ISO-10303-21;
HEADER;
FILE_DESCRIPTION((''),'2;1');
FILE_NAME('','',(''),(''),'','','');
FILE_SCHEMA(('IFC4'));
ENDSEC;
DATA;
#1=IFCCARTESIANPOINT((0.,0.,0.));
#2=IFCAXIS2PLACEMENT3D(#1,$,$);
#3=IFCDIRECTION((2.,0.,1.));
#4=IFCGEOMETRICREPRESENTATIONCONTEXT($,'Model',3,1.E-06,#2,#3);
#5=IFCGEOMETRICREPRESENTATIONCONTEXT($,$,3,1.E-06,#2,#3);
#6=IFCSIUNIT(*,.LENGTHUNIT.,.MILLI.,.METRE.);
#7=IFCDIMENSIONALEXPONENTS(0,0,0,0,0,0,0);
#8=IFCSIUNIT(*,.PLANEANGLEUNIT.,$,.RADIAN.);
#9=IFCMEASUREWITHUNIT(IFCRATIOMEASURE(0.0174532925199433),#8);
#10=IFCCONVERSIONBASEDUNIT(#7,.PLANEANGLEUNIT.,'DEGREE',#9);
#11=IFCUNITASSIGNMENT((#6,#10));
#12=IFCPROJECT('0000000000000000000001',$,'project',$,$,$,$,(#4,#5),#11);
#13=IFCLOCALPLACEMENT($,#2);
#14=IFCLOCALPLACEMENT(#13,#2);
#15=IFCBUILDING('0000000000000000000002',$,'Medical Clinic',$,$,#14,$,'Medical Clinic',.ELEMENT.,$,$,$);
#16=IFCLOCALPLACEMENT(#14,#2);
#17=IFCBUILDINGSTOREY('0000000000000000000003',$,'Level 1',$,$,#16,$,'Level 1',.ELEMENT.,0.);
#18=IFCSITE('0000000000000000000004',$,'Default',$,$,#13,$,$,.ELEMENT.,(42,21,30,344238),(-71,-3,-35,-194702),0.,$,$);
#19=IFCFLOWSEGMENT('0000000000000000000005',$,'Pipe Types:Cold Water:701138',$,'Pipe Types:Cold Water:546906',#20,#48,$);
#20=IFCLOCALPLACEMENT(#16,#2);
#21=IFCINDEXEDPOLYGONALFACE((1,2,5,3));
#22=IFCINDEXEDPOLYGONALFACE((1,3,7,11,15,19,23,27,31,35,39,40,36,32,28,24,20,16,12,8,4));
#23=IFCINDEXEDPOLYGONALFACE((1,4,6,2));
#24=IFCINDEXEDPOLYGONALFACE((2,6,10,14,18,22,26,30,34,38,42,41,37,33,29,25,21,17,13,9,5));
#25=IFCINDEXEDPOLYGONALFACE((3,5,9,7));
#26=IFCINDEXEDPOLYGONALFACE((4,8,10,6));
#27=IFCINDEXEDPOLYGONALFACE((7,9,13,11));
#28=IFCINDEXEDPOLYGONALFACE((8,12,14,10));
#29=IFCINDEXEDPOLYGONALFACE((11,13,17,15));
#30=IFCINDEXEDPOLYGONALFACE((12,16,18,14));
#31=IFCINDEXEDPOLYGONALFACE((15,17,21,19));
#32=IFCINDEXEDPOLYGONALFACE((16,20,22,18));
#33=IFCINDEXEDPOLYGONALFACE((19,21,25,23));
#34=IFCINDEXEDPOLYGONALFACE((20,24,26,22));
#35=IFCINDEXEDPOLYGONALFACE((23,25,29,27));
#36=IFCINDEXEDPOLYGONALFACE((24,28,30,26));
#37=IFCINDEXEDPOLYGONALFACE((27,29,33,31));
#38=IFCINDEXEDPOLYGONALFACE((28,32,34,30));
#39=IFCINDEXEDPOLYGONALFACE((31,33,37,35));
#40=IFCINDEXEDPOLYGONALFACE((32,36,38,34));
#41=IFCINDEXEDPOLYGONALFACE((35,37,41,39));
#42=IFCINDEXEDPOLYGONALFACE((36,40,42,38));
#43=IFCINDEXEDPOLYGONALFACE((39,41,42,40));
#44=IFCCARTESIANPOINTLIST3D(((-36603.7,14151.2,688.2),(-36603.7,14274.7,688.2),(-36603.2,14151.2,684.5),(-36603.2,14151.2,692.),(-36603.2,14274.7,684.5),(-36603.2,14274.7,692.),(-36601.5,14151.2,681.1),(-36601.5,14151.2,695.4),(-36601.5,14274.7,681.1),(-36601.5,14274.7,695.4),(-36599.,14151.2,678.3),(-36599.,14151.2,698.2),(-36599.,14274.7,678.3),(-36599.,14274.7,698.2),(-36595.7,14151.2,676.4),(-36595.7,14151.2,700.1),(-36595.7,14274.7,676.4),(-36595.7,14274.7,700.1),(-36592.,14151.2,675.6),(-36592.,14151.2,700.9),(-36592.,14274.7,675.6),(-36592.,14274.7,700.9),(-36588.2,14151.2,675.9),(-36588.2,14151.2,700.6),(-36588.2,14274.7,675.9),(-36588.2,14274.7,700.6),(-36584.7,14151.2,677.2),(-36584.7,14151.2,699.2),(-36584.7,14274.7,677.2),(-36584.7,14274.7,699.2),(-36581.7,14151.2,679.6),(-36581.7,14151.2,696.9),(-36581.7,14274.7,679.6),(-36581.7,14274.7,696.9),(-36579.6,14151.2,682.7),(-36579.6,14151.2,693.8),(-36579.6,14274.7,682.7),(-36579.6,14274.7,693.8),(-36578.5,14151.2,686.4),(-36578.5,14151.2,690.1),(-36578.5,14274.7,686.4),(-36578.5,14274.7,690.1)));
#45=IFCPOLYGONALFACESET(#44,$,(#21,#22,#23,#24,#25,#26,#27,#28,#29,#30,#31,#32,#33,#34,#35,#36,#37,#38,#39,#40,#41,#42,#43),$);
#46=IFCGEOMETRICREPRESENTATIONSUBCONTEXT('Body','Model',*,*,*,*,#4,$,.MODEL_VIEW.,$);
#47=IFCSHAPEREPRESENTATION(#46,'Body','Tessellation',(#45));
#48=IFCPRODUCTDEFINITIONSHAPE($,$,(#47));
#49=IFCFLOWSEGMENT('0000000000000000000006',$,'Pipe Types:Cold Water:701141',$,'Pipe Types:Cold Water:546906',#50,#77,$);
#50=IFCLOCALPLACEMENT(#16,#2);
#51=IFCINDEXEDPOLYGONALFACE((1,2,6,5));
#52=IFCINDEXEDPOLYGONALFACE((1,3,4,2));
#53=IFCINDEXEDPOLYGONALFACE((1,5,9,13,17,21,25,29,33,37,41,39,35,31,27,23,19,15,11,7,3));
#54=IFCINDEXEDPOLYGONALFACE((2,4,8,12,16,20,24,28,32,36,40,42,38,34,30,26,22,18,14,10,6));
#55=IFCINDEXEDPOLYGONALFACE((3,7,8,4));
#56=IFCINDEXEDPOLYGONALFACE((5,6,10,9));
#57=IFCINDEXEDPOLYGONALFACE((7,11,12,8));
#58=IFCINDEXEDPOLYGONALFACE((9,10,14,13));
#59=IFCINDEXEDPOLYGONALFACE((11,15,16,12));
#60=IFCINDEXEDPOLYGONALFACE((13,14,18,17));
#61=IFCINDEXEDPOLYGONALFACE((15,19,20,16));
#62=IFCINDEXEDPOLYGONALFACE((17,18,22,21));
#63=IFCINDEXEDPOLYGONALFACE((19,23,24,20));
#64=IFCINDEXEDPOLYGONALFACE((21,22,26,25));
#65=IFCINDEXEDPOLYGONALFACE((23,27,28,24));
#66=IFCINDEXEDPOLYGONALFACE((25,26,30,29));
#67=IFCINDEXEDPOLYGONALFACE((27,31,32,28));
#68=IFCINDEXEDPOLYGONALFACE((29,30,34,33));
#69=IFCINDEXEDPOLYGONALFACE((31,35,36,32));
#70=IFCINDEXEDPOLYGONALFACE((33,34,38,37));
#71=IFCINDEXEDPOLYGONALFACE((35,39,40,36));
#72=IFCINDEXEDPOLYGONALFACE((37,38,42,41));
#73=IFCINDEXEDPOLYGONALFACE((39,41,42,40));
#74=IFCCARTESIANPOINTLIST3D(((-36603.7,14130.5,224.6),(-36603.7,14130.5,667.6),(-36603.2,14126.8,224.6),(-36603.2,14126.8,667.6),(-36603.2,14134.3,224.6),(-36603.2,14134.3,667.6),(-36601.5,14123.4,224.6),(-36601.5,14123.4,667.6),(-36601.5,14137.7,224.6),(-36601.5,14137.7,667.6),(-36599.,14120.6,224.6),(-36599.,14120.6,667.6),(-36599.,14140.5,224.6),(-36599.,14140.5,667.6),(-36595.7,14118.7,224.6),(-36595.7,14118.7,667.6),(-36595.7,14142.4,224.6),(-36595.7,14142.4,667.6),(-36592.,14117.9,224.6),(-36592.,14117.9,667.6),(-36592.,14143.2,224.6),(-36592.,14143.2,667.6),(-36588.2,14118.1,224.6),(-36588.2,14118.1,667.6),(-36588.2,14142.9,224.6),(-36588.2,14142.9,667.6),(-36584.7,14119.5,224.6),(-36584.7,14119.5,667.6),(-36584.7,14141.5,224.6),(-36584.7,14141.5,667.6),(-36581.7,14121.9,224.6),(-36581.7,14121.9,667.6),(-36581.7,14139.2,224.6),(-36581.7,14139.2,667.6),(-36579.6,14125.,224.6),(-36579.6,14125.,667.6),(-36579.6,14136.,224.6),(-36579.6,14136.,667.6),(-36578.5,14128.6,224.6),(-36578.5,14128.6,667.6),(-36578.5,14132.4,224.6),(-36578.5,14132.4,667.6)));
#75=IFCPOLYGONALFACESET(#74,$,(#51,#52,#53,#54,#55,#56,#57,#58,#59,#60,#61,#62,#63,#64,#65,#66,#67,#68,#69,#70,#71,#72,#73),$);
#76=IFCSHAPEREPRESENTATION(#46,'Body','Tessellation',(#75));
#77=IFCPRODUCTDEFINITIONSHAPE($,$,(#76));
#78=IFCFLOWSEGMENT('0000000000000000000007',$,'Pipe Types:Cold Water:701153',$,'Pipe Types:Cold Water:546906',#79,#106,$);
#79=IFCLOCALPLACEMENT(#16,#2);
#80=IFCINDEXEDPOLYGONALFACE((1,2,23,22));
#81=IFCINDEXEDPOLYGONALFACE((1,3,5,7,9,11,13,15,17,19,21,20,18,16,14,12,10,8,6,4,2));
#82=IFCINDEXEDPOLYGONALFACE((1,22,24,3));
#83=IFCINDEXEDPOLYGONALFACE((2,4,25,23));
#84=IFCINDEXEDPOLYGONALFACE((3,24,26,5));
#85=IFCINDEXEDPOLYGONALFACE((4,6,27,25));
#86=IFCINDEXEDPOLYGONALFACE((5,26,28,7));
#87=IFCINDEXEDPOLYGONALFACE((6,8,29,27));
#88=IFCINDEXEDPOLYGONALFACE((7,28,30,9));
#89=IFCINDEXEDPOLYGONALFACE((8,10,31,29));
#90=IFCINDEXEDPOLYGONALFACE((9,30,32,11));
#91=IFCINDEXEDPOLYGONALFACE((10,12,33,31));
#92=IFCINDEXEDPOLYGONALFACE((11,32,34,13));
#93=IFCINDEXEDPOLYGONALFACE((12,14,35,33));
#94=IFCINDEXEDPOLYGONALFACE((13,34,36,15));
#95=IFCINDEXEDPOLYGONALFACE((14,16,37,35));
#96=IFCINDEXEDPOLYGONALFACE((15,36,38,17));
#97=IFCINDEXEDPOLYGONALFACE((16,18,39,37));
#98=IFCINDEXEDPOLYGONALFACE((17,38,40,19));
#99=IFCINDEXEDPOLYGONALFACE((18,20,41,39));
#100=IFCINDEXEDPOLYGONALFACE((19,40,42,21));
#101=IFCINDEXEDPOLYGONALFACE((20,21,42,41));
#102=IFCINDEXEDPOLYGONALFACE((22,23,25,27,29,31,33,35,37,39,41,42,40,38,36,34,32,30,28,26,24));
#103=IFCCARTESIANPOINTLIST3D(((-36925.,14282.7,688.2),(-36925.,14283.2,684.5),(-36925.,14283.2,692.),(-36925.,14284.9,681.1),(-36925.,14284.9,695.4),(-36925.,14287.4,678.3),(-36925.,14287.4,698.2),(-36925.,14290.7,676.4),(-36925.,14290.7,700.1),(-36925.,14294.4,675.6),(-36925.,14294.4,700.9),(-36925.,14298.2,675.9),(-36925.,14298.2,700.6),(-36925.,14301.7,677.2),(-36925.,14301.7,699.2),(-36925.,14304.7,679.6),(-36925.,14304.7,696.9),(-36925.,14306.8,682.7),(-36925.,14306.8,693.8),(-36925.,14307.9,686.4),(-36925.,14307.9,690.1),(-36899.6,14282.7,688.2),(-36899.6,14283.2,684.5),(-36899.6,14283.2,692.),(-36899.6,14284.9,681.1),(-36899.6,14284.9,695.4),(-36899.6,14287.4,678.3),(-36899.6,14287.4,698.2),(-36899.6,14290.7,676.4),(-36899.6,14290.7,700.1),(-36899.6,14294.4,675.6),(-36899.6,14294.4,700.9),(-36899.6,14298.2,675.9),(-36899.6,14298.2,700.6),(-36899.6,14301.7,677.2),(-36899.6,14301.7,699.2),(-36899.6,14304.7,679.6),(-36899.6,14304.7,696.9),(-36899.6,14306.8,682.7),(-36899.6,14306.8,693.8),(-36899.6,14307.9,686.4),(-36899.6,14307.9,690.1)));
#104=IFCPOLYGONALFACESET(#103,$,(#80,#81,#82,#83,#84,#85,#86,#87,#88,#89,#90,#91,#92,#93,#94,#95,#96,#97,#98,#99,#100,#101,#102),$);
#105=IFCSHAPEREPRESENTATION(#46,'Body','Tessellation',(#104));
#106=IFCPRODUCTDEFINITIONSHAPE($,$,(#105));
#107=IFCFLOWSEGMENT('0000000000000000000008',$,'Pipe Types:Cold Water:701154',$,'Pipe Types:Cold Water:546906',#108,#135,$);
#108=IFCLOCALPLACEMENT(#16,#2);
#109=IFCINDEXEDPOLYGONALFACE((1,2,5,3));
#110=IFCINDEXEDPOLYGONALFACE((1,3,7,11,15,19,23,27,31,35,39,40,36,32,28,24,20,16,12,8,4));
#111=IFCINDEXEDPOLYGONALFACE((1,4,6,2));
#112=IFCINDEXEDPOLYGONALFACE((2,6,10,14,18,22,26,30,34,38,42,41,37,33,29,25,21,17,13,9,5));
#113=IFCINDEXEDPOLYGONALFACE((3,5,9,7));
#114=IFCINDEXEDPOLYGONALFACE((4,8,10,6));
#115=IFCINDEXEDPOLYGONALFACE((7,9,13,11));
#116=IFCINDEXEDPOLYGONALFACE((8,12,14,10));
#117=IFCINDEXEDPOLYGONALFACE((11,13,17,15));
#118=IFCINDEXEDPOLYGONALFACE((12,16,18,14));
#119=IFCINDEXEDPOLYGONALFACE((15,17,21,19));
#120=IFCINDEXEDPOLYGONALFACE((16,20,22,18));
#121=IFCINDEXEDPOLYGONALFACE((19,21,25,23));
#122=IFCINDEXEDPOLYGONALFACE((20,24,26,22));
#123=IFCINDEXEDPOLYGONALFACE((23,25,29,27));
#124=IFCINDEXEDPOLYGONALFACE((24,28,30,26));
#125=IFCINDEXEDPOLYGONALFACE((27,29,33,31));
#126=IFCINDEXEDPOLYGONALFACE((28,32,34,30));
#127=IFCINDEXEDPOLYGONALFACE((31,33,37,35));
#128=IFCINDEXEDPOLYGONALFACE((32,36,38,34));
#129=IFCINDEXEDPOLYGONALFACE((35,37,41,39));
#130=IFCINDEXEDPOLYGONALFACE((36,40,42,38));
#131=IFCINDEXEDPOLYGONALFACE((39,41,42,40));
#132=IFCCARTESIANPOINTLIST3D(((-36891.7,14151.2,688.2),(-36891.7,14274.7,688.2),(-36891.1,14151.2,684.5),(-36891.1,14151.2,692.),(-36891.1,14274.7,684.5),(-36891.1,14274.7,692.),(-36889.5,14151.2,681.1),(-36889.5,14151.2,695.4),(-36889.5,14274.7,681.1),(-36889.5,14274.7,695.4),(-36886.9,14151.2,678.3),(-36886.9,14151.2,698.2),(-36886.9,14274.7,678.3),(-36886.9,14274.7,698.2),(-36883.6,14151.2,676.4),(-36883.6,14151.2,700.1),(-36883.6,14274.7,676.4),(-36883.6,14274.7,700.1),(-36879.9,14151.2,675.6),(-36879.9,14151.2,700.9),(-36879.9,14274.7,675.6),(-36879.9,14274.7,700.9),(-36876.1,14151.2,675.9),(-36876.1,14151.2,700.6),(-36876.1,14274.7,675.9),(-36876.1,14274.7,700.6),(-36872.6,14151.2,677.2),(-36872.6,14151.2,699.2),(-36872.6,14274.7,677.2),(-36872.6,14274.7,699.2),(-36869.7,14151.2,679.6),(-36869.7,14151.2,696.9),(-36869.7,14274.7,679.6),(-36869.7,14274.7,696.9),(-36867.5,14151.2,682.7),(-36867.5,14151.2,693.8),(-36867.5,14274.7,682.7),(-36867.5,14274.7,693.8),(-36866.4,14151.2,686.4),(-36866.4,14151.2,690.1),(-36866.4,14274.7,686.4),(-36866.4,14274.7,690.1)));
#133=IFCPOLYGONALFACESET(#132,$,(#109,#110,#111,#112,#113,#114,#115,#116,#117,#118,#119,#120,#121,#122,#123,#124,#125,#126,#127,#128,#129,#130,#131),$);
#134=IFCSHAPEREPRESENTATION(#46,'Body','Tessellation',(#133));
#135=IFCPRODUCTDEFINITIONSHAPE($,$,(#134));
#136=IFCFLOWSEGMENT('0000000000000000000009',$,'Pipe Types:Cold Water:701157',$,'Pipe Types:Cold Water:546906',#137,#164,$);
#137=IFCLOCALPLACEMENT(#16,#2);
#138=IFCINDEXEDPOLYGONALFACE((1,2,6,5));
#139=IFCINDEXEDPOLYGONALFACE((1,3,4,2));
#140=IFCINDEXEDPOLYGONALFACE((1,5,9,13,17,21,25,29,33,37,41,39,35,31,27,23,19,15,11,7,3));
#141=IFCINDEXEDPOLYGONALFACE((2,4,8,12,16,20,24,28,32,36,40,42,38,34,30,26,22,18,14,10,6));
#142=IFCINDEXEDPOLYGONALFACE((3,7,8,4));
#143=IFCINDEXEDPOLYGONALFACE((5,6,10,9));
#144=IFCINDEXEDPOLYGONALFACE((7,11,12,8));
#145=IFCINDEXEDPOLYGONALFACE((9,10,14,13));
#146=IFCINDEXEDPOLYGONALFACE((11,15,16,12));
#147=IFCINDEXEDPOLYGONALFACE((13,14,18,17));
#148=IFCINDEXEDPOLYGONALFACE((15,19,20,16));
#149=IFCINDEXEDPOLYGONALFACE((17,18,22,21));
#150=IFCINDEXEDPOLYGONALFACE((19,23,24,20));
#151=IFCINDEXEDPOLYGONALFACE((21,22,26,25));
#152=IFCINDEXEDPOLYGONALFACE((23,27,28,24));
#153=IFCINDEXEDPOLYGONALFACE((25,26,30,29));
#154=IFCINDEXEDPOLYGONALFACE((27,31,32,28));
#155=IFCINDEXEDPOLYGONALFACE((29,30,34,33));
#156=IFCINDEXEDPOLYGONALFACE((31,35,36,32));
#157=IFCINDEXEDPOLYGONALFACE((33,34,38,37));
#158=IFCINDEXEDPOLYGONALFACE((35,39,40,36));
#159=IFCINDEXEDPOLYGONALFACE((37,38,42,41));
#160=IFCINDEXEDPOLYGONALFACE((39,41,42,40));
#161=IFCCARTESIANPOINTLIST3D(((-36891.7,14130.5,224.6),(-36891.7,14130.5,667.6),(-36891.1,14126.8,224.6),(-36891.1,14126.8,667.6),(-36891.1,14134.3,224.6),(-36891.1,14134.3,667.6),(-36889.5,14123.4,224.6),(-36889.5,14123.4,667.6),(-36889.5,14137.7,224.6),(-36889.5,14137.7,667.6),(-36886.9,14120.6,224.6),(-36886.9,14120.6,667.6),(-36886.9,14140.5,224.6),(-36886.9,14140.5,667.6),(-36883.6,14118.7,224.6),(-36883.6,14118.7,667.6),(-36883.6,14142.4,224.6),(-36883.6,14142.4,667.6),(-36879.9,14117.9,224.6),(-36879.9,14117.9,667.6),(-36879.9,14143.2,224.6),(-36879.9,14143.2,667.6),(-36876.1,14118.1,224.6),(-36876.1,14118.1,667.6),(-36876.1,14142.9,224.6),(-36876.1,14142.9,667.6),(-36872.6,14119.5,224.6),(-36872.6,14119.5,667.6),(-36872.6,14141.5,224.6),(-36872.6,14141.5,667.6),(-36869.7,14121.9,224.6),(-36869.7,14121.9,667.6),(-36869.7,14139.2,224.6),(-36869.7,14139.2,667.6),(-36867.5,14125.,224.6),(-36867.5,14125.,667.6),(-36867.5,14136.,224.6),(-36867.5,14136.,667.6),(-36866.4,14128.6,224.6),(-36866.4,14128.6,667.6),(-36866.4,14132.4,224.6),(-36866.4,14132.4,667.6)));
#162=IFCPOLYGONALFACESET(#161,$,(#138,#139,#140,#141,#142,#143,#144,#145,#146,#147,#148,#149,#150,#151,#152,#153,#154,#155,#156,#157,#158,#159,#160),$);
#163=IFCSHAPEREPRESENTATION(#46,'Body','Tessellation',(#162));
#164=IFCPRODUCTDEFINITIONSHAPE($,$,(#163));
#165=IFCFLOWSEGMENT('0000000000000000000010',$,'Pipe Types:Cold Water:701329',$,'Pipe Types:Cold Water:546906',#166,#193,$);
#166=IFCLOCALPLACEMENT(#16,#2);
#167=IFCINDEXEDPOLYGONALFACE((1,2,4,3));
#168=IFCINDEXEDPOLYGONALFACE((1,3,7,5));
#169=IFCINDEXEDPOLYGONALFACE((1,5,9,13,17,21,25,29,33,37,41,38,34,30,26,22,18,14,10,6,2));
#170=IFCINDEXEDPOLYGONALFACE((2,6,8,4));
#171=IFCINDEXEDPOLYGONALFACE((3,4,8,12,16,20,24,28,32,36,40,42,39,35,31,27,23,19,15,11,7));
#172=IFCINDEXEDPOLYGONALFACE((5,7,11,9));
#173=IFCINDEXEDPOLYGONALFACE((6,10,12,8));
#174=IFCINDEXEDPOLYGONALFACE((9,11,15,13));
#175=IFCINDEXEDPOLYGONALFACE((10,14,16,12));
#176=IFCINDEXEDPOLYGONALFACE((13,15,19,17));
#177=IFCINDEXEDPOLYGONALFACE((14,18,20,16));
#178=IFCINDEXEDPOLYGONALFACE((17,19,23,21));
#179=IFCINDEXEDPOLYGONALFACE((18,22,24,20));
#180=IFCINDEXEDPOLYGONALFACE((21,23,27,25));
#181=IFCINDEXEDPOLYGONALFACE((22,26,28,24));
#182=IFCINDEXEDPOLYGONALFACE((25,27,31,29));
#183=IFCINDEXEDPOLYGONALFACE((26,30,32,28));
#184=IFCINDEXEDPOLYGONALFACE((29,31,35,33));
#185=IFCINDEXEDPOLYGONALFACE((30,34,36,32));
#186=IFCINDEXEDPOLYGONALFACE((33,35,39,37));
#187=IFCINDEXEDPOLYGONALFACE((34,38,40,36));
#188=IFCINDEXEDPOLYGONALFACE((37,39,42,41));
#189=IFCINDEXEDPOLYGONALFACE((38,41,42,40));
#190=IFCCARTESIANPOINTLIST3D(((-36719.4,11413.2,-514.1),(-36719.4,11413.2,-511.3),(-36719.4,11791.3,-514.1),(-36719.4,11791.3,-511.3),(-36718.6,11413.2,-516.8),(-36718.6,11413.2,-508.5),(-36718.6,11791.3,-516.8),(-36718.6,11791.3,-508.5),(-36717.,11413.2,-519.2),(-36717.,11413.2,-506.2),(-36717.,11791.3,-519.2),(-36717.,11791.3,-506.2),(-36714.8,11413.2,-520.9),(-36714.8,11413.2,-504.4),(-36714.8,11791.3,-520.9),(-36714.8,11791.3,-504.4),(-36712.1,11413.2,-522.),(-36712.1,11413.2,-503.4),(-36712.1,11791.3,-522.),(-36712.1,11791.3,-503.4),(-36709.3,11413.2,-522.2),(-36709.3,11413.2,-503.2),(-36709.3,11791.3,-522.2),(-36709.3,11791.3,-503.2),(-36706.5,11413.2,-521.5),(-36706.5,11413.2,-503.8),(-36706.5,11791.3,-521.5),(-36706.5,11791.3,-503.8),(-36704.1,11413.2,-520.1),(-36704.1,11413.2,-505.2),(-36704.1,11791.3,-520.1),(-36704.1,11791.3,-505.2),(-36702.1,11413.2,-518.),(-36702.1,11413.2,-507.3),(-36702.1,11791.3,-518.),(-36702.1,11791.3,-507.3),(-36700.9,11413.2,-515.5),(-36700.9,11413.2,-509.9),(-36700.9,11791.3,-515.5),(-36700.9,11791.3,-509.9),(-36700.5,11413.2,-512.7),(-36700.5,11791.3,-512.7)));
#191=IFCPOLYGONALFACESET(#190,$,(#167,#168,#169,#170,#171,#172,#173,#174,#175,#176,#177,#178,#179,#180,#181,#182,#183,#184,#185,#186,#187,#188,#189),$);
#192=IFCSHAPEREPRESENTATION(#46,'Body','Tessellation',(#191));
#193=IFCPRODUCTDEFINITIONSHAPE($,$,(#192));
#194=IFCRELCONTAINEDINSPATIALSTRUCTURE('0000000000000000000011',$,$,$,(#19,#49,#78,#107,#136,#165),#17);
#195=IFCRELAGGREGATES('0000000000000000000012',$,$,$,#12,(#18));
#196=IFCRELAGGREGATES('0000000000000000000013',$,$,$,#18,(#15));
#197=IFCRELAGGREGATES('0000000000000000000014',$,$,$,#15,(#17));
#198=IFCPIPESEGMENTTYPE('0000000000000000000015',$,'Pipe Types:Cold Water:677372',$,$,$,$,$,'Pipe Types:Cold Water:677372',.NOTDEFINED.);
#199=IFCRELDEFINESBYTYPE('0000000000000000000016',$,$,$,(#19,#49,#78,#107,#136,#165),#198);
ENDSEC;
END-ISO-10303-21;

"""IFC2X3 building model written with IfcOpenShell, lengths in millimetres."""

from ifc_helpers import new_model, entity, si_unit, converted_unit, direction, frame, frame_2d, origin, origin_2d_with_axis, place, context, subcontext, project, spatial, circle, extrude, type_object, element, save


model = new_model("IFC2X3")

# Units and contexts
model_context = context("Model", 3, precision=1e-06, world=origin(), true_north=direction((2.0, 0.0, 1.0)))
context_of_model = context(None, 3, precision=1e-06, world=origin(), true_north=direction((2.0, 0.0, 1.0)))
body_context = subcontext(model_context, "Body", "Model", "MODEL_VIEW")
ifc_project = project(units=[si_unit("LENGTHUNIT", "METRE", prefix="MILLI"), converted_unit("PLANEANGLEUNIT", "DEGREE", entity("IfcRatioMeasure", 0.0174532925199433), si_unit("PLANEANGLEUNIT", "RADIAN"), dimensions=[0, 0, 0, 0, 0, 0, 0])], contexts=[model_context, context_of_model])

# Site, building, storey
site_placement = place(None, origin())
site = spatial("IfcSite", under=ifc_project, at=site_placement, Name="Default", CompositionType="ELEMENT", RefLatitude=(42, 21, 30, 344238), RefLongitude=(-71, -3, -35, -194702), RefElevation=0.0)
building_placement = place(site_placement, origin())
building = spatial("IfcBuilding", under=site, at=building_placement, Name="Medical Clinic", LongName="Medical Clinic", CompositionType="ELEMENT")
storey_placement = place(building_placement, origin())
storey = spatial("IfcBuildingStorey", under=building, at=storey_placement, Name="Level 1", LongName="Level 1", CompositionType="ELEMENT", Elevation=0.0)

# Flow segments
pipe_segment_type_1 = type_object("IfcPipeSegmentType", Name="Pipe Types:Cold Water:677372", ElementType="Pipe Types:Cold Water:677372", PredefinedType="NOTDEFINED")
flow_segment_1_placement = place(storey_placement, origin())
element("IfcFlowSegment", 1, at=flow_segment_1_placement, inside=storey, type_object=pipe_segment_type_1, Name="Pipe Types:Cold Water:701138", ObjectType="Pipe Types:Cold Water:546906", context=body_context, shape_type="SweptSolid", body=[
    extrude(circle(Radius=12.7, at=frame_2d((0.0, 0.0), x_axis=(1.0, 0.0))), frame((-36591.0, 14151.2, 688.2), z_axis=(0.0, 1.0, 0.0), x_axis=(-1.0, 0.0, 0.0)), (0.0, 0.0, 1.0), 123.6),
])
flow_segment_2_placement = place(storey_placement, origin())
element("IfcFlowSegment", 2, at=flow_segment_2_placement, inside=storey, type_object=pipe_segment_type_1, Name="Pipe Types:Cold Water:701141", ObjectType="Pipe Types:Cold Water:546906", context=body_context, shape_type="SweptSolid", body=[
    extrude(circle(Radius=12.7, at=origin_2d_with_axis()), frame((-36591.0, 14130.5, 224.6), z_axis=(0.0, 0.0, 1.0), x_axis=(-1.0, 0.0, 0.0)), (0.0, 0.0, 1.0), 443.0),
])
flow_segment_3_placement = place(storey_placement, origin())
element("IfcFlowSegment", 3, at=flow_segment_3_placement, inside=storey, type_object=pipe_segment_type_1, Name="Pipe Types:Cold Water:701153", ObjectType="Pipe Types:Cold Water:546906", context=body_context, shape_type="SweptSolid", body=[
    extrude(circle(Radius=12.7, at=frame_2d((0.0, 0.0), x_axis=(1.0, 0.0))), frame((-36925.0, 14295.4, 688.2), z_axis=(1.0, 0.0, 0.0), x_axis=(0.0, -1.0, 0.0)), (0.0, 0.0, 1.0), 25.4),
])
flow_segment_4_placement = place(storey_placement, origin())
element("IfcFlowSegment", 4, at=flow_segment_4_placement, inside=storey, type_object=pipe_segment_type_1, Name="Pipe Types:Cold Water:701154", ObjectType="Pipe Types:Cold Water:546906", context=body_context, shape_type="SweptSolid", body=[
    extrude(circle(Radius=12.7, at=frame_2d((0.0, 0.0), x_axis=(1.0, 0.0))), frame((-36879.0, 14151.2, 688.2), z_axis=(0.0, 1.0, 0.0), x_axis=(-1.0, 0.0, 0.0)), (0.0, 0.0, 1.0), 123.6),
])
flow_segment_5_placement = place(storey_placement, origin())
element("IfcFlowSegment", 5, at=flow_segment_5_placement, inside=storey, type_object=pipe_segment_type_1, Name="Pipe Types:Cold Water:701157", ObjectType="Pipe Types:Cold Water:546906", context=body_context, shape_type="SweptSolid", body=[
    extrude(circle(Radius=12.7, at=origin_2d_with_axis()), frame((-36879.0, 14130.5, 224.6), z_axis=(0.0, 0.0, 1.0), x_axis=(-1.0, 0.0, 0.0)), (0.0, 0.0, 1.0), 443.0),
])
flow_segment_6_placement = place(storey_placement, origin())
element("IfcFlowSegment", 6, at=flow_segment_6_placement, inside=storey, type_object=pipe_segment_type_1, Name="Pipe Types:Cold Water:701329", ObjectType="Pipe Types:Cold Water:546906", context=body_context, shape_type="SweptSolid", body=[
    extrude(circle(Radius=9.5, at=origin_2d_with_axis()), frame((-36710.0, 11413.2, -512.7), z_axis=(0.0, 1.0, 0.0), x_axis=(1.0, 0.0, 0.0)), (0.0, 0.0, 1.0), 378.1),
])

save(model, "model.ifc")
